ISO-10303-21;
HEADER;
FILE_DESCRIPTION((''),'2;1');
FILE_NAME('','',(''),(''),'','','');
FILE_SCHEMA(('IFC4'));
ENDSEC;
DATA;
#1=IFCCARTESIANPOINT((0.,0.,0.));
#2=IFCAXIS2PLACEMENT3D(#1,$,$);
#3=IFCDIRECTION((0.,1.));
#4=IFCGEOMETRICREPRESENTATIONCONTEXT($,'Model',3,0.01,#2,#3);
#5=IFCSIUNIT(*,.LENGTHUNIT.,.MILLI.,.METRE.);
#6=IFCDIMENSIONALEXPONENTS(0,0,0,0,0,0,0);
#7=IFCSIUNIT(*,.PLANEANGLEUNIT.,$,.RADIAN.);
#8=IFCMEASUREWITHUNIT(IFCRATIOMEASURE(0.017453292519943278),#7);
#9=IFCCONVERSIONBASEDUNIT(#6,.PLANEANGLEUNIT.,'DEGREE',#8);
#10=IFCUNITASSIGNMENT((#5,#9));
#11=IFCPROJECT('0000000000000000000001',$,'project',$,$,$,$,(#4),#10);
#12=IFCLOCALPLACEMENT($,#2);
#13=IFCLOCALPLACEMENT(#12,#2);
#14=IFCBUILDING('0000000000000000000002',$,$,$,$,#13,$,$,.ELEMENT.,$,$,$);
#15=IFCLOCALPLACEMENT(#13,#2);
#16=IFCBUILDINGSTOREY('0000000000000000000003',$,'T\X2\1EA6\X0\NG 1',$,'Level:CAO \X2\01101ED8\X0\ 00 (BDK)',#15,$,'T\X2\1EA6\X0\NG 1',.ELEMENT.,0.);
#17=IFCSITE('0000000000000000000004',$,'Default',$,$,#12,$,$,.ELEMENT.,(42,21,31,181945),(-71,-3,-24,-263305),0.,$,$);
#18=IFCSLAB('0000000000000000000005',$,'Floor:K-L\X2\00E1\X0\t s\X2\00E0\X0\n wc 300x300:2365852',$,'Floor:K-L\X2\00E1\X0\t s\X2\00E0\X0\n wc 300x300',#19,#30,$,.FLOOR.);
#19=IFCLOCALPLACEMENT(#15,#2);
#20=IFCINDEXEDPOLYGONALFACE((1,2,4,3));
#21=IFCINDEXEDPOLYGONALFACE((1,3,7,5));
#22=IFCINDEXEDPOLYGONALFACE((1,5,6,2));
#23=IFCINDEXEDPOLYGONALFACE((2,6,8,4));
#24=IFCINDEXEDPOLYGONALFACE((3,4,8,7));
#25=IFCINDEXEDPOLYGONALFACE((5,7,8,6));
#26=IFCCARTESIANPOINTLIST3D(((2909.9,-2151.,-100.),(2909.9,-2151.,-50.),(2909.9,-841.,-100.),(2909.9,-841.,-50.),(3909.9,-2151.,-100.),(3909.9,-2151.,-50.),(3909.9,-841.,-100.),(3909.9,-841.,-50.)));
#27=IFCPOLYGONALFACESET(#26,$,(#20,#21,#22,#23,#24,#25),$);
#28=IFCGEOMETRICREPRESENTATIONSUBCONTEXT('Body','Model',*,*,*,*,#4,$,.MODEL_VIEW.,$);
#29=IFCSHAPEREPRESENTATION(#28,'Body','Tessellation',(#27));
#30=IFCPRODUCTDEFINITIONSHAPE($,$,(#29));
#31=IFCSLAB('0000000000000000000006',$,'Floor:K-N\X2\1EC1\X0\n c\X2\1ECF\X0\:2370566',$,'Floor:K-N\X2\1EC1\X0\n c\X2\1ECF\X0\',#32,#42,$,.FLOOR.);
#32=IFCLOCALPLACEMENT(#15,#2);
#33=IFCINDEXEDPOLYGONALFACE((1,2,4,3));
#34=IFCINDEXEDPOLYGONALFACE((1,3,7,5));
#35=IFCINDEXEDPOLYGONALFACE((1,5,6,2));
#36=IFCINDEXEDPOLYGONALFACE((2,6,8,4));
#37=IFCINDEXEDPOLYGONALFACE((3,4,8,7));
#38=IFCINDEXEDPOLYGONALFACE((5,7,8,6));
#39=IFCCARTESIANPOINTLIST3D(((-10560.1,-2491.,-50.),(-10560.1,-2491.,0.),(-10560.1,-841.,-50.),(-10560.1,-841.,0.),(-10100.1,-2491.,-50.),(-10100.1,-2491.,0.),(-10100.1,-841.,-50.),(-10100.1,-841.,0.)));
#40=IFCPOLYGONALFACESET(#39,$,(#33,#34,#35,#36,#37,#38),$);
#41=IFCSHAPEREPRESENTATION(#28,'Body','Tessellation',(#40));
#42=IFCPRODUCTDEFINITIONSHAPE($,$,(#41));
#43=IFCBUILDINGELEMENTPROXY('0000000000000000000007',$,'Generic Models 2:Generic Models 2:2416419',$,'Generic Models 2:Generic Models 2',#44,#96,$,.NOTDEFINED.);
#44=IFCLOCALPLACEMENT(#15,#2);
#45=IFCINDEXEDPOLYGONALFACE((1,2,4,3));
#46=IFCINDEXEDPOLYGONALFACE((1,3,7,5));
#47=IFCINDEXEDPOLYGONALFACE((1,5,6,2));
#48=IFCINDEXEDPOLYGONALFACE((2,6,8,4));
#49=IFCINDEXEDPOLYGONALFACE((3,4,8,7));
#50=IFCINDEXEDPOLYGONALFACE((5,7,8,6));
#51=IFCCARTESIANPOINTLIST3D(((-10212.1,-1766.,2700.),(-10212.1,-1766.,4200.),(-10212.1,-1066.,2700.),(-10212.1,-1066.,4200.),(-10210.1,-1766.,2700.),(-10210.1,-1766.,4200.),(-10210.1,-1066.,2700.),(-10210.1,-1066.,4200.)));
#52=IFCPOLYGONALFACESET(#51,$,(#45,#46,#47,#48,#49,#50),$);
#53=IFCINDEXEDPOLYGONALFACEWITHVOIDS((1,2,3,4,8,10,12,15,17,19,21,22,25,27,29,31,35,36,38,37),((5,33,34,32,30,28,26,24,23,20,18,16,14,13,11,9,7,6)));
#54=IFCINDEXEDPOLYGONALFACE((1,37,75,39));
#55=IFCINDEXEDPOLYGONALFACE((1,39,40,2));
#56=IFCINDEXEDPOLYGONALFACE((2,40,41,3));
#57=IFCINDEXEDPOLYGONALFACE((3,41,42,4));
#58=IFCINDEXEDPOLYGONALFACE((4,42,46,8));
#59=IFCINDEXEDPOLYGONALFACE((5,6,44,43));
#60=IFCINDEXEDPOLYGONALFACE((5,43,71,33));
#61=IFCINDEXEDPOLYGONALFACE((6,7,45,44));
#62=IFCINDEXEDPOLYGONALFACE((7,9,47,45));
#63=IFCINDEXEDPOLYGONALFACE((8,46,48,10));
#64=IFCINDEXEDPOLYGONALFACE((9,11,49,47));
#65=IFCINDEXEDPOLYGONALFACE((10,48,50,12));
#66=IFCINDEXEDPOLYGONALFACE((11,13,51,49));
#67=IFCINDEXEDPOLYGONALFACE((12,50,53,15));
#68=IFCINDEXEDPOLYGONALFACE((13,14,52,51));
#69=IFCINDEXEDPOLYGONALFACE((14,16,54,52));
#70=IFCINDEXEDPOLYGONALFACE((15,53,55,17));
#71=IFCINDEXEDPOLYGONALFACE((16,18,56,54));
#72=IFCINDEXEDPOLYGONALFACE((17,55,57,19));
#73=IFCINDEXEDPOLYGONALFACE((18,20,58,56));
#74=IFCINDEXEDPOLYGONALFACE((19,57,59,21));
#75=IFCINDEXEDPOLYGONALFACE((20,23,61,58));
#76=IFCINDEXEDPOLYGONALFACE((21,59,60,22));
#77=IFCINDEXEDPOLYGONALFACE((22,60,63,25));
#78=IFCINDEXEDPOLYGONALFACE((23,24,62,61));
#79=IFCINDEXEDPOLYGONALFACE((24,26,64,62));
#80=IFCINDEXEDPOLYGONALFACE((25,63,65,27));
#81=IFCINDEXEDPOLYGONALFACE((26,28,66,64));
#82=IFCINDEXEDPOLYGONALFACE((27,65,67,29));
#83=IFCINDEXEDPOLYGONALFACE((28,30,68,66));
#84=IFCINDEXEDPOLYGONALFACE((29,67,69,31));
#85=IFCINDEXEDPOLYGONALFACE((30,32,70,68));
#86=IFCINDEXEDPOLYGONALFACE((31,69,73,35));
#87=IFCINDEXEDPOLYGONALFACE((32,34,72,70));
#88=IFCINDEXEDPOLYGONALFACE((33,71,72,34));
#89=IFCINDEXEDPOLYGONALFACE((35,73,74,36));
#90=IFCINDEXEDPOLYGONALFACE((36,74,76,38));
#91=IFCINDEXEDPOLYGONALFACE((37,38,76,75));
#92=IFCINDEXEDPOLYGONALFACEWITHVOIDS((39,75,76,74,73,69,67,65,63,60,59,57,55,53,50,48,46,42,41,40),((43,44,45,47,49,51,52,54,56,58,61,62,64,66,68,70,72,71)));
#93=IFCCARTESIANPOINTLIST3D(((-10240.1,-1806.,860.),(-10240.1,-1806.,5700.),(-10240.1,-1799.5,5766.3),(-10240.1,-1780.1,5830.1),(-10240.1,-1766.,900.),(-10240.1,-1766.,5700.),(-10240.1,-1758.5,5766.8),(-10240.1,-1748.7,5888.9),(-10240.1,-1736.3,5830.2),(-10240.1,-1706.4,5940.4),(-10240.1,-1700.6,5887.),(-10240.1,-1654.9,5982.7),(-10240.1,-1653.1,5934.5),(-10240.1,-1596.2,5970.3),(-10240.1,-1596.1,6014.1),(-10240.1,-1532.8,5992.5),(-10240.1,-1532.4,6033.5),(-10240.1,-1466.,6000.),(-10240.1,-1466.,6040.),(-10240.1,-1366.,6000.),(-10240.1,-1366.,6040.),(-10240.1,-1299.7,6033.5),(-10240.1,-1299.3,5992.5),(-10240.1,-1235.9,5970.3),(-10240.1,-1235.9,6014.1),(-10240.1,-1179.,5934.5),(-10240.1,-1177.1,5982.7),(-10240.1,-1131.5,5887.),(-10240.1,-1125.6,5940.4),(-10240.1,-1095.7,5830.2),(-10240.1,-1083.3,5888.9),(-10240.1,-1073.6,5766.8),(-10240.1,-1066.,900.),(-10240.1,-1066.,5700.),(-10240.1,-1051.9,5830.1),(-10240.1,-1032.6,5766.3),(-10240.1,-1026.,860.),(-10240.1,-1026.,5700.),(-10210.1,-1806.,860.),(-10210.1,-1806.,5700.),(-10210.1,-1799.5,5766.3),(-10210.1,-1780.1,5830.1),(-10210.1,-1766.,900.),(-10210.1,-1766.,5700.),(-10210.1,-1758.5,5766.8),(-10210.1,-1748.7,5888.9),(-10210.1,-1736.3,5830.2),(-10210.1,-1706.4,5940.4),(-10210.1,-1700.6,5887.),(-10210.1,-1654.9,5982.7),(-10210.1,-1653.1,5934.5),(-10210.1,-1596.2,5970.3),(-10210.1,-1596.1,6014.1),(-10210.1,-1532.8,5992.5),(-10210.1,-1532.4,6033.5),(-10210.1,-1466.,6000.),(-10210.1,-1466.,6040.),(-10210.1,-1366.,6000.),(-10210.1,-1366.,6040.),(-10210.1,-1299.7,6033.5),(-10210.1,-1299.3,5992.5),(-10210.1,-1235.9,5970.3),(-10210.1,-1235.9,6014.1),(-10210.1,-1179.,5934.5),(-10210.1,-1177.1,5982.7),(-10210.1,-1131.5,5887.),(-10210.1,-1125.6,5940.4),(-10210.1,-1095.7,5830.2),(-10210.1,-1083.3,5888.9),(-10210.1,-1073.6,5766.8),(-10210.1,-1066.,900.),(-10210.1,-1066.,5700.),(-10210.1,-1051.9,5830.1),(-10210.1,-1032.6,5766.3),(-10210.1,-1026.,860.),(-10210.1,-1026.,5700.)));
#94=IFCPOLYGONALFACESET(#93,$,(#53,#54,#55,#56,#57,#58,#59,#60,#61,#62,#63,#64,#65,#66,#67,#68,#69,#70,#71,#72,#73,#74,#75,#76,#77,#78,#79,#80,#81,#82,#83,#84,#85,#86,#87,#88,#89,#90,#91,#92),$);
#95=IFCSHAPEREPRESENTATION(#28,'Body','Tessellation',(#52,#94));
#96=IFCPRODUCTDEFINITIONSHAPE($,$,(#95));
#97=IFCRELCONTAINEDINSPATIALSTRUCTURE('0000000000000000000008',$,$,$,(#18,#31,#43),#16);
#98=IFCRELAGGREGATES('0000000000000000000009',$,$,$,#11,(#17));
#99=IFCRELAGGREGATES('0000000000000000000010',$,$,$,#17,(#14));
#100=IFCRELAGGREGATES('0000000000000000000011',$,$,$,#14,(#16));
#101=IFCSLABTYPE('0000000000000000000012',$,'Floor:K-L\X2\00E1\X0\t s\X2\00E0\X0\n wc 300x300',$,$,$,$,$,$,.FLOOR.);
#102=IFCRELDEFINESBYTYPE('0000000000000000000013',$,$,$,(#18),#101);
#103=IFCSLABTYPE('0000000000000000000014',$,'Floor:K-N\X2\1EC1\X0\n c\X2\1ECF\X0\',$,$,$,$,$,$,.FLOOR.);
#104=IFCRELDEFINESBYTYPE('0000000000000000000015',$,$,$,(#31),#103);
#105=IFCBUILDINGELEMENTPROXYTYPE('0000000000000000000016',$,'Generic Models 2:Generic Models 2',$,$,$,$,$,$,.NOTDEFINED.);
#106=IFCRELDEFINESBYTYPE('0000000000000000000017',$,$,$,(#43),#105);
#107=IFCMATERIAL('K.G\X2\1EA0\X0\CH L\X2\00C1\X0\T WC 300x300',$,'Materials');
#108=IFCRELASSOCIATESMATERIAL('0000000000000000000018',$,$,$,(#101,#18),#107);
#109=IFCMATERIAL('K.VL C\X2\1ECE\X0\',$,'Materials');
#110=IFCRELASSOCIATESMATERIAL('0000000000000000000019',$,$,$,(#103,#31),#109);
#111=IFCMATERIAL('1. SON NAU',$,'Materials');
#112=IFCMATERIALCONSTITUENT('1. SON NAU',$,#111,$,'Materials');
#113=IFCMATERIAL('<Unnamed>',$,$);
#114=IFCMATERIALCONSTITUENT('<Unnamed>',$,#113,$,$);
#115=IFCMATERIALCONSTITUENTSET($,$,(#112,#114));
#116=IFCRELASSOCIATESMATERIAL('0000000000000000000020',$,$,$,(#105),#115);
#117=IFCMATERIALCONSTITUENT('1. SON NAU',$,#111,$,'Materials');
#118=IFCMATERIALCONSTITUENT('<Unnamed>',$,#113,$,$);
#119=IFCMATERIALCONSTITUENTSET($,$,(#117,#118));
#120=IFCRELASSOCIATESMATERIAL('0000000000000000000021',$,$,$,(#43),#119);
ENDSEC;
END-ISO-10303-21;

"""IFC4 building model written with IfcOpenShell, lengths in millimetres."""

from ifc_helpers import new_model, entity, si_unit, converted_unit, direction, frame, origin, place, context, subcontext, project, spatial, line, arc, indexed_curve, outline, extrude, source, transform, mapped, material, constituent, constituent_set, type_object, type_shapes, element, save


model = new_model("IFC4")

# Units and contexts
model_context = context("Model", 3, precision=0.01, world=origin(), true_north=direction((0.0, 1.0)))
body_context = subcontext(model_context, "Body", "Model", "MODEL_VIEW")
ifc_project = project(units=[si_unit("LENGTHUNIT", "METRE", prefix="MILLI"), converted_unit("PLANEANGLEUNIT", "DEGREE", entity("IfcRatioMeasure", 0.017453292519943278), si_unit("PLANEANGLEUNIT", "RADIAN"), dimensions=[0, 0, 0, 0, 0, 0, 0])], contexts=[model_context])

# Site, building, storey
site_placement = place(None, origin())
site = spatial("IfcSite", under=ifc_project, at=site_placement, Name="Default", CompositionType="ELEMENT", RefLatitude=(42, 21, 31, 181945), RefLongitude=(-71, -3, -24, -263305), RefElevation=0.0)
building_placement = place(site_placement, origin())
building = spatial("IfcBuilding", under=site, at=building_placement, CompositionType="ELEMENT")
storey_placement = place(building_placement, origin())
storey = spatial("IfcBuildingStorey", under=building, at=storey_placement, Name="TẦNG 1", ObjectType="Level:CAO ĐỘ 00 (BDK)", LongName="TẦNG 1", CompositionType="ELEMENT", Elevation=0.0)

# Slabs
ifc_material_1 = material(Name="K.GẠCH LÁT WC 300x300", Category="Materials")
slab_type_1 = type_object("IfcSlabType", Name="Floor:K-Lát sàn wc 300x300", PredefinedType="FLOOR", material=ifc_material_1)
slab_1_placement = place(storey_placement, origin())
element("IfcSlab", 1, at=slab_1_placement, inside=storey, type_object=slab_type_1, material=ifc_material_1, Name="Floor:K-Lát sàn wc 300x300:2365852", ObjectType="Floor:K-Lát sàn wc 300x300", PredefinedType="FLOOR", context=body_context, shape_type="SweptSolid", body=[
    extrude(outline(indexed_curve([(-655.0, -500.0), (655.0, -500.0), (655.0, 500.0), (-655.0, 500.0), (-655.0, -500.0)], self_intersect=False)), frame((3409.9, -1496.0, -50.0), z_axis=(0.0, 0.0, -1.0), x_axis=(0.0, 1.0, 0.0)), (0.0, 0.0, 1.0), 50.0),
])
ifc_material_2 = material(Name="K.VL CỎ", Category="Materials")
slab_type_2 = type_object("IfcSlabType", Name="Floor:K-Nền cỏ", PredefinedType="FLOOR", material=ifc_material_2)
slab_2_placement = place(storey_placement, origin())
element("IfcSlab", 2, at=slab_2_placement, inside=storey, type_object=slab_type_2, material=ifc_material_2, Name="Floor:K-Nền cỏ:2370566", ObjectType="Floor:K-Nền cỏ", PredefinedType="FLOOR", context=body_context, shape_type="SweptSolid", body=[
    extrude(outline(indexed_curve([(-825.0, -230.0), (825.0, -230.0), (825.0, 230.0), (-825.0, 230.0), (-825.0, -230.0)], self_intersect=False)), frame((-10330.1, -1666.0, 0.0), z_axis=(0.0, 0.0, -1.0), x_axis=(0.0, 1.0, 0.0)), (0.0, 0.0, 1.0), 50.0),
])

# Building element proxy
ifc_material_3 = material(Name="<Unnamed>")
ifc_material_4 = material(Name="1. SON NAU", Category="Materials")
ifc_constituent_1 = constituent(ifc_material_4, Name="1. SON NAU", Category="Materials")
ifc_constituent_2 = constituent(ifc_material_3, Name="<Unnamed>")
ifc_constituent_set_1 = constituent_set(constituents=[ifc_constituent_1, ifc_constituent_2])
ifc_constituent_3 = constituent(ifc_material_4, Name="1. SON NAU", Category="Materials")
ifc_constituent_4 = constituent(ifc_material_3, Name="<Unnamed>")
ifc_constituent_set_2 = constituent_set(constituents=[ifc_constituent_3, ifc_constituent_4])
building_element_proxy_type_1 = type_object("IfcBuildingElementProxyType", Name="Generic Models 2:Generic Models 2", PredefinedType="NOTDEFINED", material=ifc_constituent_set_2)
shared_shape_1 = source(origin(), body_context, "Body", "SweptSolid", [
    extrude(outline(indexed_curve([(-1.0, -350.0), (1.0, -350.0), (1.0, 350.0), (-1.0, 350.0), (-1.0, -350.0)], self_intersect=False)), frame((-10211.1, -1416.0, 2700.0)), (0.0, 0.0, 1.0), 1500.0),
    extrude(outline(indexed_curve([(-50.0, -1840.0), (50.0, -1840.0), (290.4, -1740.4), (390.0, -1500.0), (390.0, 3340.0), (-390.0, 3340.0), (-390.0, -1500.0), (-290.4, -1740.4)], segments=[line(1, 2), arc(2, 3, 4), line(4, 5, 6, 7), arc(7, 8, 1)], self_intersect=False), holes=[indexed_curve([(-350.0, -1500.0), (-350.0, 3300.0), (350.0, 3300.0), (350.0, -1500.0), (262.1, -1712.1), (50.0, -1800.0), (-50.0, -1800.0), (-262.1, -1712.1)], segments=[line(1, 2, 3, 4), arc(4, 5, 6), line(6, 7), arc(7, 8, 1)], self_intersect=False)]), frame((-10240.1, -1416.0, 4200.0), z_axis=(1.0, 0.0, 0.0), x_axis=(0.0, -1.0, 0.0)), (0.0, 0.0, 1.0), 30.0),
])
type_shapes(building_element_proxy_type_1, [shared_shape_1])
proxy_1_placement = place(storey_placement, origin())
element("IfcBuildingElementProxy", 3, at=proxy_1_placement, inside=storey, type_object=building_element_proxy_type_1, material=ifc_constituent_set_1, Name="Generic Models 2:Generic Models 2:2416419", ObjectType="Generic Models 2:Generic Models 2", PredefinedType="NOTDEFINED", context=body_context, shape_type="MappedRepresentation", body=[
    mapped(shared_shape_1, transform((0.0, 0.0, 0.0), scale=1.0)),
])

save(model, "model.ifc")
